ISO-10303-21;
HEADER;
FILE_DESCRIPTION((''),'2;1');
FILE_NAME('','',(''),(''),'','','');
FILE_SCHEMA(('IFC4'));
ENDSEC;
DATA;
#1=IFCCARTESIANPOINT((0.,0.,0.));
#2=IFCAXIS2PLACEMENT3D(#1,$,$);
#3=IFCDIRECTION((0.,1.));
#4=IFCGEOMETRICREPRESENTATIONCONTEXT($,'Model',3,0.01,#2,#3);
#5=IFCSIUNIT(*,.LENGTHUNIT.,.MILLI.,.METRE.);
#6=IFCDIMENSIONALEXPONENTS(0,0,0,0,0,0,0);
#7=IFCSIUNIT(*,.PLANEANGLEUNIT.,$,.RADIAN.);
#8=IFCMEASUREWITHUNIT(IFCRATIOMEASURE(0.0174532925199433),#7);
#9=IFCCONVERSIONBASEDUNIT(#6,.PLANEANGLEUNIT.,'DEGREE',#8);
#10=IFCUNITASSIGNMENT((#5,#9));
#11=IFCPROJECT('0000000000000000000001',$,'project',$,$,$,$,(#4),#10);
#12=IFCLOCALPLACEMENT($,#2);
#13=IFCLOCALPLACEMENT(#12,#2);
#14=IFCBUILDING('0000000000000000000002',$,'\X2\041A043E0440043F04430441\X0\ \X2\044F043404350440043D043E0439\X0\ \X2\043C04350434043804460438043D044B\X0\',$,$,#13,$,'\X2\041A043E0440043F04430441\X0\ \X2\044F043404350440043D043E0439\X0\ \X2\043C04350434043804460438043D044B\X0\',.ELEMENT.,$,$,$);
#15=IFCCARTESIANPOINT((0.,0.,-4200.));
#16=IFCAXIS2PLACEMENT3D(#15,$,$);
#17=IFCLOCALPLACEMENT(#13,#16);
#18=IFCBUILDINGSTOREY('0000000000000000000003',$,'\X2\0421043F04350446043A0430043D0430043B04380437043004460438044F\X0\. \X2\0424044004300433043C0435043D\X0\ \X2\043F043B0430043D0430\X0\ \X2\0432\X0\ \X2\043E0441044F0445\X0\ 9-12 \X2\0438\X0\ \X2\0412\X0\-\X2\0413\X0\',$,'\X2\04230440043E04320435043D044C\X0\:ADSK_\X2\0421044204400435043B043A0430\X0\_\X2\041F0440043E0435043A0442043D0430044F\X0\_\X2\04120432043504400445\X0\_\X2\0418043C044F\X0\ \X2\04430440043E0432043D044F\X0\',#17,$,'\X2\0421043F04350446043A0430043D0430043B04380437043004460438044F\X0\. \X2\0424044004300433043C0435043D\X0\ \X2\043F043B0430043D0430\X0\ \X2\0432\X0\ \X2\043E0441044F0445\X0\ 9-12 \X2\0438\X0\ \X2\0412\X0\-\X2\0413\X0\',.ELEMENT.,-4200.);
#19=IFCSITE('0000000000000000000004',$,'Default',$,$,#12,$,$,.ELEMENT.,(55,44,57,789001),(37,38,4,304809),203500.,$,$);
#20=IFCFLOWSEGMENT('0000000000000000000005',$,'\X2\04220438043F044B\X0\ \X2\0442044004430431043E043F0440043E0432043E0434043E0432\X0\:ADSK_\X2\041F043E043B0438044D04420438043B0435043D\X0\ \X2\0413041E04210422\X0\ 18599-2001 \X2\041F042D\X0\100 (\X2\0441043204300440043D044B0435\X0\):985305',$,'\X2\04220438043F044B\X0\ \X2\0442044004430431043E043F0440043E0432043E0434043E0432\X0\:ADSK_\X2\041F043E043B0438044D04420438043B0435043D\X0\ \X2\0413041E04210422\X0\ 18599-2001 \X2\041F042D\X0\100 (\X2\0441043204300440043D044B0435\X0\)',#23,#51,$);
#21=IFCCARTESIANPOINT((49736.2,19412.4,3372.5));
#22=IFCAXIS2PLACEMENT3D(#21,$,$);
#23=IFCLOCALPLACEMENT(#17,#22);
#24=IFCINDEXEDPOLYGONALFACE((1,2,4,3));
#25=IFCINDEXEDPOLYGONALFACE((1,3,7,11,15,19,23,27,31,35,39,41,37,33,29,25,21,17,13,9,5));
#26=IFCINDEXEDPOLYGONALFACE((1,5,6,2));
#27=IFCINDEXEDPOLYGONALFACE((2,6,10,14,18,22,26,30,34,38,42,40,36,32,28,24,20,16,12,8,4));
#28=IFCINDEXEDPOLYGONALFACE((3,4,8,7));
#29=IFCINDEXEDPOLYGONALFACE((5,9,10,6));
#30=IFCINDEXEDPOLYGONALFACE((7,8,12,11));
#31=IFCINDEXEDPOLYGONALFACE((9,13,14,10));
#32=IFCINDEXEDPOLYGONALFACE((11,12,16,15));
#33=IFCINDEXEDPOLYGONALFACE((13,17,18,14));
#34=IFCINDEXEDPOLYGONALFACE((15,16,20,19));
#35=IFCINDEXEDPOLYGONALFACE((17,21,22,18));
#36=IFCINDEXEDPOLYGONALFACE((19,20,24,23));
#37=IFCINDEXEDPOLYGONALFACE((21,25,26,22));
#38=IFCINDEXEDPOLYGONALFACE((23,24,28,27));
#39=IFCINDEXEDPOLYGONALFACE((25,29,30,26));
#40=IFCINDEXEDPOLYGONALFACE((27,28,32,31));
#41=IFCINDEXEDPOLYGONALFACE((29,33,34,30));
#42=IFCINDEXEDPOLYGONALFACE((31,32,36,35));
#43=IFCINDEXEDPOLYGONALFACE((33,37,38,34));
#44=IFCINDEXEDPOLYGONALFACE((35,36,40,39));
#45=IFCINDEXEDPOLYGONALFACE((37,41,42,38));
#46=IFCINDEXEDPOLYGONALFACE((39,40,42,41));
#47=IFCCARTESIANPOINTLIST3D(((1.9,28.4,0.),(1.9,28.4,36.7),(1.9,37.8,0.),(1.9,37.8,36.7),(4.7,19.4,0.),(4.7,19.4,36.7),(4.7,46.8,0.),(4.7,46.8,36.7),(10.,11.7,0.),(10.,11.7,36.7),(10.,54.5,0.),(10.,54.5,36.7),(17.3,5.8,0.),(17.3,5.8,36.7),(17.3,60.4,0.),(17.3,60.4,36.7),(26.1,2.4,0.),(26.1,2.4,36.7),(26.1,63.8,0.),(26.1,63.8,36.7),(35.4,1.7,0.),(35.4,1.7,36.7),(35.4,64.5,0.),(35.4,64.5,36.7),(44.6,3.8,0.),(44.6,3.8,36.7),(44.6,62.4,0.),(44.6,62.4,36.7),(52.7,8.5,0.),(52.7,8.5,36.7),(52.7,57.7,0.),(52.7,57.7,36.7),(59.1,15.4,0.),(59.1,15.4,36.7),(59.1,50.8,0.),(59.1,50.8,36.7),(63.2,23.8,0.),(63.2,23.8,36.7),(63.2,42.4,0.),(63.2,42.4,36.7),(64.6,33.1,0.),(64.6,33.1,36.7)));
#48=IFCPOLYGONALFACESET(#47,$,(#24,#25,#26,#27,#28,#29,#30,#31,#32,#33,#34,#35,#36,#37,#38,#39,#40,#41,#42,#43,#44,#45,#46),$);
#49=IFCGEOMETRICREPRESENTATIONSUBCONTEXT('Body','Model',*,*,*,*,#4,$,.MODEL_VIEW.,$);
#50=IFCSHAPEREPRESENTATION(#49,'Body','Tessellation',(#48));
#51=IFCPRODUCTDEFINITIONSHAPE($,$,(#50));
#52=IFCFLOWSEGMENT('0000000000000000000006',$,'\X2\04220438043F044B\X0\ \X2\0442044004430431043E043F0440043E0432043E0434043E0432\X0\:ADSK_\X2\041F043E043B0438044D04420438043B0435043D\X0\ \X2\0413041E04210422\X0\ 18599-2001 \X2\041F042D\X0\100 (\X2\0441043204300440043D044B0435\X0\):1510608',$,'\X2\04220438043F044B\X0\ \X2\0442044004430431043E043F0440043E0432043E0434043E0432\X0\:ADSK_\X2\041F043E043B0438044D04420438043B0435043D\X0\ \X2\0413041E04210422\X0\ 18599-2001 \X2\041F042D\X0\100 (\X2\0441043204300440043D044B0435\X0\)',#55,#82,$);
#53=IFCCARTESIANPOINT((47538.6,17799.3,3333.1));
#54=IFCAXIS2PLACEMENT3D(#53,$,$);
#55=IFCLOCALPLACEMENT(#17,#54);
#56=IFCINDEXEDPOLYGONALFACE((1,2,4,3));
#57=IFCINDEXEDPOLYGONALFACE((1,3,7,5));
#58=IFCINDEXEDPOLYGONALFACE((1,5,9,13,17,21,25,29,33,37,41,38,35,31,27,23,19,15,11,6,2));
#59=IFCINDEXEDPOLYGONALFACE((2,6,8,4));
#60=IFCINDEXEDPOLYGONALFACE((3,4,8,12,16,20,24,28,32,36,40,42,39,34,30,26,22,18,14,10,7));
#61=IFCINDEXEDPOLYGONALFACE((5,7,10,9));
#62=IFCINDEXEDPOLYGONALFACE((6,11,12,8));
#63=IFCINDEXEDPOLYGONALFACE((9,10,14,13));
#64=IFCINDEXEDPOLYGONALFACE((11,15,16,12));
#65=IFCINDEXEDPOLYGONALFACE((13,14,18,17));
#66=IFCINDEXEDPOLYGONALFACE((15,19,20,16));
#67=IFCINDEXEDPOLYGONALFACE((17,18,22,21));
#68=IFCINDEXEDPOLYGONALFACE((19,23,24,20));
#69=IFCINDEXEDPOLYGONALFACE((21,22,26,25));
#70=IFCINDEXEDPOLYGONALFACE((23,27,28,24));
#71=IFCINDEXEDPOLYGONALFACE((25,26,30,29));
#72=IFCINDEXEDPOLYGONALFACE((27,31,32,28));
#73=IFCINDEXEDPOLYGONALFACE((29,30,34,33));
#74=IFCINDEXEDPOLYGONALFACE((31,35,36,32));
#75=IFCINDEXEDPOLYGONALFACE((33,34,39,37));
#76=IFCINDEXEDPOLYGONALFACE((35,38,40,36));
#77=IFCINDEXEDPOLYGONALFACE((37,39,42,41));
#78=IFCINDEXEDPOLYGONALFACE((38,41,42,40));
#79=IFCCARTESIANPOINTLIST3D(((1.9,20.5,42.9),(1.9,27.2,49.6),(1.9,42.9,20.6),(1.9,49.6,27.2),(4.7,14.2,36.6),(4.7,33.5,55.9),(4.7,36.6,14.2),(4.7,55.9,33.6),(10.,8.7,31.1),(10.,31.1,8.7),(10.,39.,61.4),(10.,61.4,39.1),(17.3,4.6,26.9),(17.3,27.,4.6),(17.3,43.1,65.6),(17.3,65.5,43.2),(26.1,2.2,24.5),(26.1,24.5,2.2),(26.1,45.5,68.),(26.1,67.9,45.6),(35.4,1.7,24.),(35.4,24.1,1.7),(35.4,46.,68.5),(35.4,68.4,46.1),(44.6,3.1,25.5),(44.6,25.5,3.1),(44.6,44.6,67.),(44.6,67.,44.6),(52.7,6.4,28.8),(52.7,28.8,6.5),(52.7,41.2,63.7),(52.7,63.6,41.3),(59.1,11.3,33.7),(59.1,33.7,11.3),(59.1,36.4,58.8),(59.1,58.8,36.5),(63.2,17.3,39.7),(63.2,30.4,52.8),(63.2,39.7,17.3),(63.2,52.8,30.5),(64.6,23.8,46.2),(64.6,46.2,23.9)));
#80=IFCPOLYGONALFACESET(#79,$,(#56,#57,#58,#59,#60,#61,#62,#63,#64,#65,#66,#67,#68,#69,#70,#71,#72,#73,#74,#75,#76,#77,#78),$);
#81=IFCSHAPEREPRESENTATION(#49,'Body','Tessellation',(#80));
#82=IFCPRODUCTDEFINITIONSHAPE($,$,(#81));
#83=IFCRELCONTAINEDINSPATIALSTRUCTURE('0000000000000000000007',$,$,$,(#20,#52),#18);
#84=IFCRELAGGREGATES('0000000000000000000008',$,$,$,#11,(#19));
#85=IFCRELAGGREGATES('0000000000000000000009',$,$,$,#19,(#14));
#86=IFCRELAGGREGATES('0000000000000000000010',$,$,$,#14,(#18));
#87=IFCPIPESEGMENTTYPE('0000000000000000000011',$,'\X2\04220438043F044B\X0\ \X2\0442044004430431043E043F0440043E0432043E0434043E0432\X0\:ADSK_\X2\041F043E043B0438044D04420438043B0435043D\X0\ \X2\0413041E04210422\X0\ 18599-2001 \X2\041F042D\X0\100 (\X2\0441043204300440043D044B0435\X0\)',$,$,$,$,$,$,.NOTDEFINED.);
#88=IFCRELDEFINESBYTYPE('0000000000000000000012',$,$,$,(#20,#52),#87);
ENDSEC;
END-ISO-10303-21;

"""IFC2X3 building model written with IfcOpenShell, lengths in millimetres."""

from ifc_helpers import new_model, entity, si_unit, converted_unit, direction, frame, frame_2d, origin, origin_2d_with_axis, place, context, subcontext, project, spatial, circle, extrude, type_object, element, save


model = new_model("IFC2X3")

# Units and contexts
model_context = context("Model", 3, precision=0.01, world=origin(), true_north=direction((0.0, 1.0)))
body_context = subcontext(model_context, "Body", "Model", "MODEL_VIEW")
ifc_project = project(units=[si_unit("LENGTHUNIT", "METRE", prefix="MILLI"), converted_unit("PLANEANGLEUNIT", "DEGREE", entity("IfcRatioMeasure", 0.0174532925199433), si_unit("PLANEANGLEUNIT", "RADIAN"), dimensions=[0, 0, 0, 0, 0, 0, 0])], contexts=[model_context])

# Site, building, storey
site_placement = place(None, frame((0.0, 0.0, 0.0)))
site = spatial("IfcSite", under=ifc_project, at=site_placement, Name="Default", CompositionType="ELEMENT", RefLatitude=(55, 44, 57, 789001), RefLongitude=(37, 38, 4, 304809), RefElevation=203500.0)
building_placement = place(site_placement, origin())
building = spatial("IfcBuilding", under=site, at=building_placement, Name="Корпус ядерной медицины", LongName="Корпус ядерной медицины", CompositionType="ELEMENT")
storey_placement = place(building_placement, frame((0.0, 0.0, -4200.0)))
storey = spatial("IfcBuildingStorey", under=building, at=storey_placement, Name="Спецканализация. Фрагмен плана в осях 9-12 и В-Г", ObjectType="Уровень:ADSK_Стрелка_Проектная_Вверх_Имя уровня", LongName="Спецканализация. Фрагмен плана в осях 9-12 и В-Г", CompositionType="ELEMENT", Elevation=-4200.0)

# Flow segments
pipe_segment_type = type_object("IfcPipeSegmentType", Name="Типы трубопроводов:ADSK_Полиэтилен ГОСТ 18599-2001 ПЭ100 (сварные)", PredefinedType="NOTDEFINED")
flow_segment_1_placement = place(storey_placement, frame((49736.2, 19412.4, 3372.5)))
element("IfcFlowSegment", 1, at=flow_segment_1_placement, inside=storey, type_object=pipe_segment_type, Name="Типы трубопроводов:ADSK_Полиэтилен ГОСТ 18599-2001 ПЭ100 (сварные):985305", ObjectType="Типы трубопроводов:ADSK_Полиэтилен ГОСТ 18599-2001 ПЭ100 (сварные)", context=body_context, shape_type="SweptSolid", body=[
    extrude(circle(Radius=31.5, at=origin_2d_with_axis()), frame((33.1, 33.1, 0.0)), (0.0, 0.0, 1.0), 36.7),
])
flow_segment_2_placement = place(storey_placement, frame((47538.6, 17799.3, 3333.1)))
element("IfcFlowSegment", 2, at=flow_segment_2_placement, inside=storey, type_object=pipe_segment_type, Name="Типы трубопроводов:ADSK_Полиэтилен ГОСТ 18599-2001 ПЭ100 (сварные):1510608", ObjectType="Типы трубопроводов:ADSK_Полиэтилен ГОСТ 18599-2001 ПЭ100 (сварные)", context=body_context, shape_type="SweptSolid", body=[
    extrude(circle(Radius=31.5, at=frame_2d((0.0, 0.0), x_axis=(1.0, 0.0))), frame((33.1, 23.8, 46.2), z_axis=(0.0, 0.707857, -0.706356), x_axis=(1.0, 0.0, 0.0)), (0.0, 0.0, 1.0), 31.6),
])

save(model, "model.ifc")
